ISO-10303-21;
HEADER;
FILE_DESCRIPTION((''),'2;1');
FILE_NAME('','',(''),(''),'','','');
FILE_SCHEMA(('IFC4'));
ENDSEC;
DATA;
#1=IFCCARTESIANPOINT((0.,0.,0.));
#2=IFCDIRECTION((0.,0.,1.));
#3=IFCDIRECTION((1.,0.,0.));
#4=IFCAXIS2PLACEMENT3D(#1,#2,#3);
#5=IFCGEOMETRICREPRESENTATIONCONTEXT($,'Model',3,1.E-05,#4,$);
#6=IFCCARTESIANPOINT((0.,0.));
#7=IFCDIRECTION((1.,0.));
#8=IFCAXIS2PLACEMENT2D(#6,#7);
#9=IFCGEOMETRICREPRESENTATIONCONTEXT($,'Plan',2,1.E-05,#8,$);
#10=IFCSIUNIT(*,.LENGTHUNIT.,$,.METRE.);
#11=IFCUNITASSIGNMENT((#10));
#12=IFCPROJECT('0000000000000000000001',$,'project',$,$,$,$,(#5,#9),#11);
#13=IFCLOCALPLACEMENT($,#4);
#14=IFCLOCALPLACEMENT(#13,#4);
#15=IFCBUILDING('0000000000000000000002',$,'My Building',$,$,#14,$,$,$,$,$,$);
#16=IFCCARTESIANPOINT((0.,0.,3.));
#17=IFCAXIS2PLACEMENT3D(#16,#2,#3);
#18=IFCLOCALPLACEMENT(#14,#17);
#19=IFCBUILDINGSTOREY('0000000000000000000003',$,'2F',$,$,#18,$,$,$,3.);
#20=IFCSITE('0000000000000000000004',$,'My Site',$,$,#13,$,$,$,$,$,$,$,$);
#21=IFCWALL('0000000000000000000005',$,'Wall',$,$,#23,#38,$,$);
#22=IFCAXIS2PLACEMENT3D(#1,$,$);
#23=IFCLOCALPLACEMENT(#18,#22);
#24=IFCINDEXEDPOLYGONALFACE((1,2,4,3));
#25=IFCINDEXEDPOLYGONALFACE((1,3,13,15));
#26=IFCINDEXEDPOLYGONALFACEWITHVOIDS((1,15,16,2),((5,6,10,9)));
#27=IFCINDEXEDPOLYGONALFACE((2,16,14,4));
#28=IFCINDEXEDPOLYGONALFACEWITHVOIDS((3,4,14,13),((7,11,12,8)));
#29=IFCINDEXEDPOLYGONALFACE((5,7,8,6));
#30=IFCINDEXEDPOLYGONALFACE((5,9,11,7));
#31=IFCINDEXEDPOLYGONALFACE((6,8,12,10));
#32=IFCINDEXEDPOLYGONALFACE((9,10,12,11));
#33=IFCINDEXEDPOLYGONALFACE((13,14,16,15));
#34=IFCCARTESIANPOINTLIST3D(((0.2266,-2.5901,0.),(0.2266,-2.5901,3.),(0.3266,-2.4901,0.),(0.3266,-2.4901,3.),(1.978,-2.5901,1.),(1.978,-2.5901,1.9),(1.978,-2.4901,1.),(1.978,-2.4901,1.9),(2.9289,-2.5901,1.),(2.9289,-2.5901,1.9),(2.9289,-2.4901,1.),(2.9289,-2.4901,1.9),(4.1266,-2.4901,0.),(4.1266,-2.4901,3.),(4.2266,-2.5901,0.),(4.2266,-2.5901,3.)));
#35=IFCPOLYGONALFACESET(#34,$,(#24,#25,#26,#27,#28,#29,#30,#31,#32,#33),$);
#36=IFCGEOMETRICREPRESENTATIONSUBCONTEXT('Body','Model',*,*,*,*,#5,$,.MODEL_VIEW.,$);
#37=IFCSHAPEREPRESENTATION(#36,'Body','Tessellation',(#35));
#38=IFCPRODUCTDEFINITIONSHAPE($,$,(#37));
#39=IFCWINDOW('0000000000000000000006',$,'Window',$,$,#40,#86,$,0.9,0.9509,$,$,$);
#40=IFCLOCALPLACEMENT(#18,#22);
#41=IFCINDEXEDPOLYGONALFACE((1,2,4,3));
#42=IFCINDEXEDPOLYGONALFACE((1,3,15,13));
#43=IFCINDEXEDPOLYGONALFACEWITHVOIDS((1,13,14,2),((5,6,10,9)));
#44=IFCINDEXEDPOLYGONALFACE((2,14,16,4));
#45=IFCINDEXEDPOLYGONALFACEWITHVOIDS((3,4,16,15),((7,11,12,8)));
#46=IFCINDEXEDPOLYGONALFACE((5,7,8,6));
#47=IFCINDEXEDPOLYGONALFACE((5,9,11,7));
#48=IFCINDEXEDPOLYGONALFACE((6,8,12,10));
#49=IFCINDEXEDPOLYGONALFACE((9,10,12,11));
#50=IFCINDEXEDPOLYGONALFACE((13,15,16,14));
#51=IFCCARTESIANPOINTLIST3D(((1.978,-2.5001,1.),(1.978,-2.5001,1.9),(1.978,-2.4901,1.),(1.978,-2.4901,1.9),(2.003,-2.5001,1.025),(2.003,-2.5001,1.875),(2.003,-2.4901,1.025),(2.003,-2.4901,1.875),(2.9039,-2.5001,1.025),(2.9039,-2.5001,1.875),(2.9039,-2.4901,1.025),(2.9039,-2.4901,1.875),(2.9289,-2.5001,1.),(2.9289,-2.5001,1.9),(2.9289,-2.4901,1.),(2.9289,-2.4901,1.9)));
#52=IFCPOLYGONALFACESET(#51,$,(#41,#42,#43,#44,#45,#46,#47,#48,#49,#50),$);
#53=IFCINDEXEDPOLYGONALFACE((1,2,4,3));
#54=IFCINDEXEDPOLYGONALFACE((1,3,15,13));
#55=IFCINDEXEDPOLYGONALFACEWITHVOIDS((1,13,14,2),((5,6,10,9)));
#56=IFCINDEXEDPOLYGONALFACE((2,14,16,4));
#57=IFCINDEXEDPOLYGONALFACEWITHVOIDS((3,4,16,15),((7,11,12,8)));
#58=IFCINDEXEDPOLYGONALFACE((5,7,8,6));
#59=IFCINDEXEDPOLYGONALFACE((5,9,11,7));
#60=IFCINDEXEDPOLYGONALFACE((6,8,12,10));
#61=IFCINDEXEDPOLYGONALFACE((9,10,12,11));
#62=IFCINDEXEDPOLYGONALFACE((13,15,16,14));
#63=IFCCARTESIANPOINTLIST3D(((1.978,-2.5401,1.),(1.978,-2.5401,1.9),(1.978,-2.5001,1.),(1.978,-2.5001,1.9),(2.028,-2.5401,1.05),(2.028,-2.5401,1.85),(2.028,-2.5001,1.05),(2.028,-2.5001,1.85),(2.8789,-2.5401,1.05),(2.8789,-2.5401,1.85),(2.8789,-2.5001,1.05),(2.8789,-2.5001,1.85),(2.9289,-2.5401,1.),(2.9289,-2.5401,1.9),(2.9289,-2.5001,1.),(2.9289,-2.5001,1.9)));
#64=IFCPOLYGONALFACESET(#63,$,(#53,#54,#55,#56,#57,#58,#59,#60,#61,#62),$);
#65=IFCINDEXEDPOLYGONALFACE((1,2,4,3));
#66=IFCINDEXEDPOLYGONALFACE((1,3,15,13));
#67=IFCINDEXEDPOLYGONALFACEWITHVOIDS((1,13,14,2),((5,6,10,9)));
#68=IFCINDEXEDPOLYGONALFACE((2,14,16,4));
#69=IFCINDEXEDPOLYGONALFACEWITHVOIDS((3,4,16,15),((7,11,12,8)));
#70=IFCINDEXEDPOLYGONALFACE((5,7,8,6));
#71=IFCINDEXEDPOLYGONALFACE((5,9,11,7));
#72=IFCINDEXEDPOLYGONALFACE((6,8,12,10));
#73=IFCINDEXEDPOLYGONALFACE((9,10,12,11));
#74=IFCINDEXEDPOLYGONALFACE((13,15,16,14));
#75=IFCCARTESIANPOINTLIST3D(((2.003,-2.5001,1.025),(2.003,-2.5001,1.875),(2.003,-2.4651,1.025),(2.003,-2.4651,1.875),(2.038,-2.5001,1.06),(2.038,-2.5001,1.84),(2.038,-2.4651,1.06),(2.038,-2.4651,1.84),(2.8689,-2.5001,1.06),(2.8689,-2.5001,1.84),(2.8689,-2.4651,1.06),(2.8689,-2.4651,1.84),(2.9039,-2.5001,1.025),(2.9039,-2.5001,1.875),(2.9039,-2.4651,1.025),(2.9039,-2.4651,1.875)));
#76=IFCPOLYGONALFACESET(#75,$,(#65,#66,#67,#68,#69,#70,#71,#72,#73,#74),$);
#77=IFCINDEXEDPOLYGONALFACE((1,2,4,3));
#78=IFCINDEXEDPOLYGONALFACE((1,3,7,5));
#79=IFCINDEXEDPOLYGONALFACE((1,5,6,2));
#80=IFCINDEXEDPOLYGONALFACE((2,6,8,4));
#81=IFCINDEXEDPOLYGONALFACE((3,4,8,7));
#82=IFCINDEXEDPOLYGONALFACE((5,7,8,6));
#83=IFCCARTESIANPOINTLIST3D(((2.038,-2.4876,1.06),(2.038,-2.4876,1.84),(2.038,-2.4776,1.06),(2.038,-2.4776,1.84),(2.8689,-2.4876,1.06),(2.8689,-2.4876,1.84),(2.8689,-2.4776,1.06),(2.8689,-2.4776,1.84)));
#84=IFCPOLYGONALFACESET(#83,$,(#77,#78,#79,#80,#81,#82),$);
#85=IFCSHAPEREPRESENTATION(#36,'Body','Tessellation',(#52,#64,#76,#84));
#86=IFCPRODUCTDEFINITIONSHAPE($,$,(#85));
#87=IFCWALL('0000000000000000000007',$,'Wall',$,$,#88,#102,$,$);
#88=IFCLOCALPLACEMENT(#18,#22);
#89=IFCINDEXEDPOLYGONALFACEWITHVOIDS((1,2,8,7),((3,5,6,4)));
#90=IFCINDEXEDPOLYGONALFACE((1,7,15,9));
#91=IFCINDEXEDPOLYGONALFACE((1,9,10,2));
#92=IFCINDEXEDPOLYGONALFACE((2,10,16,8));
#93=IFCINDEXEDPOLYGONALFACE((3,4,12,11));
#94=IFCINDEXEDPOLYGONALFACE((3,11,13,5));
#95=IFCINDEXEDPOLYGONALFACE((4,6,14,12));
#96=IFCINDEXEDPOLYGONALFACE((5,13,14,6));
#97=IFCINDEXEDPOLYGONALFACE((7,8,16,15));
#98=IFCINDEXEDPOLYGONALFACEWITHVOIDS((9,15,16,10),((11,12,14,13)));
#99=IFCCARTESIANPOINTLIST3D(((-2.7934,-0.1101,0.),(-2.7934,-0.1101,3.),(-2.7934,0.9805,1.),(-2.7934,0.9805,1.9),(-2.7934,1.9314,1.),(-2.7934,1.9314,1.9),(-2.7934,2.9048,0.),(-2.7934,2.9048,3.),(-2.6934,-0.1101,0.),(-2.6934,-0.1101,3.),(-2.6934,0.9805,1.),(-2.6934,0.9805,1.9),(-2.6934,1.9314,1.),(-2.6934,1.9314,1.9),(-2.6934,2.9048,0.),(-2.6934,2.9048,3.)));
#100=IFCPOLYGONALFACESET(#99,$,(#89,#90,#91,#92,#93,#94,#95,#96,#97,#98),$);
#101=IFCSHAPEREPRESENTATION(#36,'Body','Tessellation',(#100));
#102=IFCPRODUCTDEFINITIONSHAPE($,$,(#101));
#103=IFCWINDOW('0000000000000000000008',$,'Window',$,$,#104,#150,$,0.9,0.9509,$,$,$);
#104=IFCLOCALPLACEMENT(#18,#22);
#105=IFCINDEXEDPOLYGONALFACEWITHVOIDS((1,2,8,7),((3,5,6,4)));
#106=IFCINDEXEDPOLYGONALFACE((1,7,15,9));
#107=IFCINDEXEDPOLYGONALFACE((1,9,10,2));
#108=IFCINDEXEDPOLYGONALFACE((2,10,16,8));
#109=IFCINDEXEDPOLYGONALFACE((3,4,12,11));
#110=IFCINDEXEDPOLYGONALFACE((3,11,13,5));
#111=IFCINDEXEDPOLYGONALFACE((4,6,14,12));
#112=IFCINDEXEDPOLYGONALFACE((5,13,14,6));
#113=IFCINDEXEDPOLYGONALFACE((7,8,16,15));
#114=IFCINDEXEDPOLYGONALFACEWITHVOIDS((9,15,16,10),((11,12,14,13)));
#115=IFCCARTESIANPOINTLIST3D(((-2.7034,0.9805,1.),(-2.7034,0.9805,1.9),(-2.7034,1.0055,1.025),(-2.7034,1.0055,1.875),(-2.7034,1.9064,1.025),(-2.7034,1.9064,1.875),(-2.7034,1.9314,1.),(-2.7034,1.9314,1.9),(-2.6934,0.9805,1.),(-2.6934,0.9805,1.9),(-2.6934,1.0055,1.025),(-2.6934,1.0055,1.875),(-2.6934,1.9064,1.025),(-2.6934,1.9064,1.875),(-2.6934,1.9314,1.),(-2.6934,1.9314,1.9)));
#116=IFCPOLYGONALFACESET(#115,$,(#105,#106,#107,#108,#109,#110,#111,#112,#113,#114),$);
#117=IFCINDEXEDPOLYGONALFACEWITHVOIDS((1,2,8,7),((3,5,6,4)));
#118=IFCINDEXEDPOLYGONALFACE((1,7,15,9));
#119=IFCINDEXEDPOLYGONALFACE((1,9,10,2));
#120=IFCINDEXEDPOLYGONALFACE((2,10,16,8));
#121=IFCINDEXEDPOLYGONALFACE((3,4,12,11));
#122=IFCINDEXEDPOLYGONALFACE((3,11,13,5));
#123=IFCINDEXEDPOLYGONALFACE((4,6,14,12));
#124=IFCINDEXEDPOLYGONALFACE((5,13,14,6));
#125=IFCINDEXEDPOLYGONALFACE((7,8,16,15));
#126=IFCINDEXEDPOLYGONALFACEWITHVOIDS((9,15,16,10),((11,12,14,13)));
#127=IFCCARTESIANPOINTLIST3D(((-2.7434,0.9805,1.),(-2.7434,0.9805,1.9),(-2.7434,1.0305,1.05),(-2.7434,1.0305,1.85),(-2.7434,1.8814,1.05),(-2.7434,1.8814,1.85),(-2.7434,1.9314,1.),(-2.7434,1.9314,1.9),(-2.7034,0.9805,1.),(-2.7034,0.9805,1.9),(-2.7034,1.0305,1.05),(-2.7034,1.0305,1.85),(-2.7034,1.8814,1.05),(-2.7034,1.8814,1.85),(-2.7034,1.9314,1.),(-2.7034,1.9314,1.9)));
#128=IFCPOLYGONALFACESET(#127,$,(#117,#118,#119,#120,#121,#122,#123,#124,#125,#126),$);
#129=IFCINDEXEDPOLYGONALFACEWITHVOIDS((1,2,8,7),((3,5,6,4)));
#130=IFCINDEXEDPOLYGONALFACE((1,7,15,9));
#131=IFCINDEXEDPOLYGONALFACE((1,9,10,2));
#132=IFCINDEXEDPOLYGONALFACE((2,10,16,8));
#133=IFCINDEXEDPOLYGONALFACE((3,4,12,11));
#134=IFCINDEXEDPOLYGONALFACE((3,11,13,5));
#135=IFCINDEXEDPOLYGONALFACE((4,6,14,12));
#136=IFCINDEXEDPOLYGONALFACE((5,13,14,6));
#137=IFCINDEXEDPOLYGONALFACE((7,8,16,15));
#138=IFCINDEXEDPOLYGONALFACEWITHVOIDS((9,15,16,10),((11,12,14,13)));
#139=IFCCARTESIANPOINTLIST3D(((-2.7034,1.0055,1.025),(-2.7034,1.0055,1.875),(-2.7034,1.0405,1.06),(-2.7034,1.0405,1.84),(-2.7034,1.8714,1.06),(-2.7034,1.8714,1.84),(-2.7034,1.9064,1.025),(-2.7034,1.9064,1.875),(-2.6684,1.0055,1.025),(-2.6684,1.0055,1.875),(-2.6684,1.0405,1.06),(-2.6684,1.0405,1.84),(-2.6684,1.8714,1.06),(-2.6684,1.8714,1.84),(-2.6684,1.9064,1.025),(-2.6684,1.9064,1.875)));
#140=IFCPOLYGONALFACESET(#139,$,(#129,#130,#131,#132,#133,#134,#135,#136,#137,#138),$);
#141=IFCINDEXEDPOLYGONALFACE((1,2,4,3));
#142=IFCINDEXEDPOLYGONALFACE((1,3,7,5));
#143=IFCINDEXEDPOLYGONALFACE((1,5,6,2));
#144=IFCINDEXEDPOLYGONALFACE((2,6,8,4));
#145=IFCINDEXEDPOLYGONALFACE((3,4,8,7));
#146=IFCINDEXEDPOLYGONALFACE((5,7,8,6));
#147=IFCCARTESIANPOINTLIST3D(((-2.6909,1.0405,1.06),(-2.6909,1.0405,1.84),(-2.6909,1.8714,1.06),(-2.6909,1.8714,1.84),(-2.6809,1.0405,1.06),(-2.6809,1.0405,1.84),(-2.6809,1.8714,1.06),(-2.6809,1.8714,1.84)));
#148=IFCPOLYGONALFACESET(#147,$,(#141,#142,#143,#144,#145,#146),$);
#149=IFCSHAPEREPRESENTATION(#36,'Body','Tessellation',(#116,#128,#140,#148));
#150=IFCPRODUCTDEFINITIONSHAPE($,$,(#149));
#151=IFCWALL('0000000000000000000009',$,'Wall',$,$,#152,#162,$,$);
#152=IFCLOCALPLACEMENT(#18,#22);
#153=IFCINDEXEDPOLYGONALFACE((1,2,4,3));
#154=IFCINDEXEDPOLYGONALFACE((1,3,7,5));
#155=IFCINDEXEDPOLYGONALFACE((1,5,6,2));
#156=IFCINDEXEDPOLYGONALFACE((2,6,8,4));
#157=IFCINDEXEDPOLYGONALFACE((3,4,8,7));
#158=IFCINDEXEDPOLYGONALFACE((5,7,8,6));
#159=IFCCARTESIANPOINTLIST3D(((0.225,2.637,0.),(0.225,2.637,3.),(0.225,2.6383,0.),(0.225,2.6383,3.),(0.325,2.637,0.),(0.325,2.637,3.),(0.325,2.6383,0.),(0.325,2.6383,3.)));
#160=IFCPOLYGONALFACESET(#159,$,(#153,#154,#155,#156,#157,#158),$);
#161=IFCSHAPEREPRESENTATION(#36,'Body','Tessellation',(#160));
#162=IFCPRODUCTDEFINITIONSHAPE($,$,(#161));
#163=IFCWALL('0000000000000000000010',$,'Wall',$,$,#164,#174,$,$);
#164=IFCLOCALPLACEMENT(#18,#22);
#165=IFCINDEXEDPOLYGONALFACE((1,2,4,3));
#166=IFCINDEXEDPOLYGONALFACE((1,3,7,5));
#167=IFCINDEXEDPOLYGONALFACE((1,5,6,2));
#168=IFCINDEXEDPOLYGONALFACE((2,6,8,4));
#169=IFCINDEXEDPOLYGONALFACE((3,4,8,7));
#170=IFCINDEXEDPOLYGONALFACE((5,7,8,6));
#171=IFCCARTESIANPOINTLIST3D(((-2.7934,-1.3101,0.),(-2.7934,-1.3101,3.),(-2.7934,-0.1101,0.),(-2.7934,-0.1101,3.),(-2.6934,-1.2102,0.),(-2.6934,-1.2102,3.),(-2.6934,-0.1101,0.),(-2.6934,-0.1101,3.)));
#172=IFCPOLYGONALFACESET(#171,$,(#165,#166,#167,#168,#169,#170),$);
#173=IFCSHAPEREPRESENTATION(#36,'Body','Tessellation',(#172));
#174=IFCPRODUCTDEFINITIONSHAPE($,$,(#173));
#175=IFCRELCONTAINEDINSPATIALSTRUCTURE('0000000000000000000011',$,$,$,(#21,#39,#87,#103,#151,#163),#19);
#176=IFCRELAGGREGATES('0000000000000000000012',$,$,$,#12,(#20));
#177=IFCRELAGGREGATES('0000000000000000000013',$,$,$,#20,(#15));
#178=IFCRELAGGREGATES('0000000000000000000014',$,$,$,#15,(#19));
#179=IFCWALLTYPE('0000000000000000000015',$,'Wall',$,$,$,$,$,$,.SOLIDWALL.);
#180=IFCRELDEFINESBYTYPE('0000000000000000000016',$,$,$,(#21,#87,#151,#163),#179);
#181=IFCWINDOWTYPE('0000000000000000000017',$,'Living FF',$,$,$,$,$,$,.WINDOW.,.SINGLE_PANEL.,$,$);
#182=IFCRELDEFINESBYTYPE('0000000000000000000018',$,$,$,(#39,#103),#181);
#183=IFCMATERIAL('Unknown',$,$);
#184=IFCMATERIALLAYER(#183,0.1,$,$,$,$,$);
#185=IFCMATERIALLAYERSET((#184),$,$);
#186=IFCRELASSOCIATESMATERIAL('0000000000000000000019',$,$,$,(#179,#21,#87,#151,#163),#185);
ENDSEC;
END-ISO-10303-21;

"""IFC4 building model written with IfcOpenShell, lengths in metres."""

from ifc_helpers import new_model, entity, si_unit, frame, origin_with_axes, origin_2d_with_axis, place, context, subcontext, project, spatial, line, indexed_curve, outline, extrude, shape, source, transform, mapped, material, layer, layer_set, layer_usage, type_object, type_shapes, element, fill, save


model = new_model("IFC4")

# Units and contexts
model_context = context("Model", 3, precision=1e-05, world=origin_with_axes())
plan_context = context("Plan", 2, precision=1e-05, world=origin_2d_with_axis())
body_context_1 = subcontext(model_context, "Body", "Model", "MODEL_VIEW")
body_context_2 = subcontext(plan_context, "Body", "Plan", "PLAN_VIEW")
ifc_project = project(units=[si_unit("LENGTHUNIT", "METRE")], contexts=[model_context, plan_context])

# Site, building, storey
site_placement = place(None, origin_with_axes())
site = spatial("IfcSite", under=ifc_project, at=site_placement, Name="My Site")
building_placement = place(site_placement, origin_with_axes())
building = spatial("IfcBuilding", under=site, at=building_placement, Name="My Building")
storey_placement = place(building_placement, frame((0.0, 0.0, 3.0), z_axis=(0.0, 0.0, 1.0), x_axis=(1.0, 0.0, 0.0)))
storey = spatial("IfcBuildingStorey", under=building, at=storey_placement, Name="2F", Elevation=3.0)

# Shared definitions
ifc_material = material(Name="Unknown")

# Shared definitions
ifc_layer_1 = layer(ifc_material, 0.1)
ifc_layer_set_1 = layer_set([ifc_layer_1])
wall_type = type_object("IfcWallType", Name="Wall", PredefinedType="SOLIDWALL", material=ifc_layer_set_1)
shared_shape_1 = source(origin_with_axes(), body_context_1, "Body", "SweptSolid", [
    extrude(outline(indexed_curve([(0.0, 0.0), (0.9509, 0.0), (0.9509, 0.9), (0.0, 0.9)], segments=[line(1, 2, 3, 4, 1)])), frame((0.0, -0.6, 0.0), z_axis=(0.0, -1.0, 0.0), x_axis=(1.0, 0.0, 0.0)), (0.0, 0.0, -1.0), 1.2),
])
window_type_1 = type_object("IfcWindowType", Name="Living FF", PartitioningType="SINGLE_PANEL", PredefinedType="WINDOW")
shared_shape_2 = source(origin_with_axes(), body_context_1, "Body", "SweptSolid", [
    extrude(outline(indexed_curve([(0.0, 0.0), (0.9509, 0.0), (0.9509, 0.9), (0.0, 0.9)], segments=[line(1, 2, 3, 4, 1)]), holes=[indexed_curve([(0.025, 0.025), (0.9259, 0.025), (0.9259, 0.875), (0.025, 0.875)], segments=[line(1, 2, 3, 4, 1)])]), frame((0.0, 0.09, 0.0), z_axis=(0.0, -1.0, 0.0), x_axis=(1.0, 0.0, 0.0)), (0.0, 0.0, -1.0), 0.01),
    extrude(outline(indexed_curve([(0.0, 0.0), (0.9509, 0.0), (0.9509, 0.9), (0.0, 0.9)], segments=[line(1, 2, 3, 4, 1)]), holes=[indexed_curve([(0.05, 0.05), (0.9009, 0.05), (0.9009, 0.85), (0.05, 0.85)], segments=[line(1, 2, 3, 4, 1)])]), frame((0.0, 0.05, 0.0), z_axis=(0.0, -1.0, 0.0), x_axis=(1.0, 0.0, 0.0)), (0.0, 0.0, -1.0), 0.04),
    extrude(outline(indexed_curve([(0.0, 0.0), (0.9009, 0.0), (0.9009, 0.85), (0.0, 0.85)], segments=[line(1, 2, 3, 4, 1)]), holes=[indexed_curve([(0.035, 0.035), (0.8659, 0.035), (0.8659, 0.815), (0.035, 0.815)], segments=[line(1, 2, 3, 4, 1)])]), frame((0.025, 0.09, 0.025), z_axis=(0.0, -1.0, 0.0), x_axis=(1.0, 0.0, 0.0)), (0.0, 0.0, -1.0), 0.035),
    extrude(outline(indexed_curve([(0.035, 0.035), (0.8659, 0.035), (0.8659, 0.815), (0.035, 0.815)], segments=[line(1, 2, 3, 4, 1)])), frame((0.025, 0.1025, 0.025), z_axis=(0.0, -1.0, 0.0), x_axis=(1.0, 0.0, 0.0)), (0.0, 0.0, -1.0), 0.01),
])
shared_shape_3 = source(origin_with_axes(), body_context_2, "Body", "Curve2D", [
    entity("IfcIndexedPolyCurve", entity("IfcCartesianPointList2D", [[0.05, 0.05], [0.9009, 0.05]])),
    entity("IfcIndexedPolyCurve", entity("IfcCartesianPointList2D", [[0.0, 0.1], [0.025, 0.1], [0.025, 0.09], [0.05, 0.09], [0.05, 0.05], [0.0, 0.05]]), [entity("IfcLineIndex", [1, 2, 3, 4, 5, 6, 1])]),
    entity("IfcIndexedPolyCurve", entity("IfcCartesianPointList2D", [[0.9509, 0.1], [0.9259, 0.1], [0.9259, 0.09], [0.9009, 0.09], [0.9009, 0.05], [0.9509, 0.05]]), [entity("IfcLineIndex", [1, 2, 3, 4, 5, 6, 1])]),
    entity("IfcIndexedPolyCurve", entity("IfcCartesianPointList2D", [[0.025, 0.09], [0.06, 0.09], [0.06, 0.125], [0.025, 0.125]]), [entity("IfcLineIndex", [1, 2, 3, 4, 1])]),
    entity("IfcIndexedPolyCurve", entity("IfcCartesianPointList2D", [[0.9259, 0.09], [0.8909, 0.09], [0.8909, 0.125], [0.9259, 0.125]]), [entity("IfcLineIndex", [1, 2, 3, 4, 1])]),
    entity("IfcIndexedPolyCurve", entity("IfcCartesianPointList2D", [[0.06, 0.09], [0.8909, 0.09]])),
    entity("IfcIndexedPolyCurve", entity("IfcCartesianPointList2D", [[0.06, 0.125], [0.8909, 0.125]])),
    entity("IfcIndexedPolyCurve", entity("IfcCartesianPointList2D", [[0.06, 0.1075], [0.8909, 0.1075]])),
])
type_shapes(window_type_1, [shared_shape_2, shared_shape_3])

# Walls, openings, windows
ifc_layer_usage_1 = layer_usage(ifc_layer_set_1, "AXIS2", "POSITIVE", 0.0)
wall_1_placement = place(storey_placement, frame((0.2266, -2.5901, 0.0), z_axis=(0.0, 0.0, 1.0), x_axis=(1.0, 0.0, 0.0)))
wall_1 = element("IfcWall", 1, at=wall_1_placement, inside=storey, type_object=wall_type, material=ifc_layer_usage_1, Name="Wall", context=body_context_1, shape_type="SweptSolid", body=[
    extrude(outline(indexed_curve([(0.0, 0.0), (0.1, 0.1), (3.9, 0.1), (4.0, 0.0)], segments=[line(1, 2, 3, 4, 1)])), origin_with_axes(), (0.0, 0.0, 1.0), 3.0),
])
opening_1_placement = place(wall_1_placement, frame((1.7514, 0.0, 1.0), z_axis=(0.0, 0.0, 1.0), x_axis=(1.0, 0.0, 0.0)))
opening_1 = element("IfcOpeningElement", 2, at=opening_1_placement, cuts=wall_1, PredefinedType="OPENING", context=body_context_1, shape_type="MappedRepresentation", body=[
    mapped(shared_shape_1, transform((0.0, 0.0, 0.0), x_axis=(1.0, 0.0, 0.0), y_axis=(0.0, 1.0, 0.0), z_axis=(0.0, 0.0, 1.0), scale=1.0)),
])
window_1_placement = place(opening_1_placement, origin_with_axes())
window_1 = element("IfcWindow", 3, at=window_1_placement, inside=storey, type_object=window_type_1, Name="Window", OverallHeight=0.9, OverallWidth=0.9509, shapes=[
    shape(body_context_1, "Body", "MappedRepresentation", [mapped(shared_shape_2, transform((0.0, 0.0, 0.0), x_axis=(1.0, 0.0, 0.0), y_axis=(0.0, 1.0, 0.0), z_axis=(0.0, 0.0, 1.0), scale=1.0))]),
    shape(body_context_2, "Body", "MappedRepresentation", [mapped(shared_shape_3, transform((0.0, 0.0, 0.0), x_axis=(1.0, 0.0, 0.0), y_axis=(0.0, 1.0, 0.0), z_axis=(0.0, 0.0, 1.0), scale=1.0))]),
])
fill(opening_1, window_1)
ifc_layer_usage_2 = layer_usage(ifc_layer_set_1, "AXIS2", "POSITIVE", 0.0)
wall_2_placement = place(storey_placement, frame((-2.7934, 2.9048, 0.0), z_axis=(0.0, 0.0, 1.0), x_axis=(0.0, -1.0, 0.0)))
wall_2 = element("IfcWall", 4, at=wall_2_placement, inside=storey, type_object=wall_type, material=ifc_layer_usage_2, Name="Wall", context=body_context_1, shape_type="SweptSolid", body=[
    extrude(outline(indexed_curve([(0.0, 0.0), (0.0, 0.1), (3.0149, 0.1), (3.0149, 0.0)], segments=[line(1, 2, 3, 4, 1)])), origin_with_axes(), (0.0, 0.0, 1.0), 3.0),
])
opening_2_placement = place(wall_2_placement, frame((0.9734, 0.0, 1.0), z_axis=(0.0, 0.0, 1.0), x_axis=(1.0, 0.0, 0.0)))
opening_2 = element("IfcOpeningElement", 5, at=opening_2_placement, cuts=wall_2, PredefinedType="OPENING", context=body_context_1, shape_type="MappedRepresentation", body=[
    mapped(shared_shape_1, transform((0.0, 0.0, 0.0), x_axis=(1.0, 0.0, 0.0), y_axis=(0.0, 1.0, 0.0), z_axis=(0.0, 0.0, 1.0), scale=1.0)),
])
window_2_placement = place(opening_2_placement, frame((0.0, 0.0, 0.0), z_axis=(0.0, 0.0, 1.0), x_axis=(1.0, 0.0, 0.0)))
window_2 = element("IfcWindow", 6, at=window_2_placement, inside=storey, type_object=window_type_1, Name="Window", OverallHeight=0.9, OverallWidth=0.9509, shapes=[
    shape(body_context_1, "Body", "MappedRepresentation", [mapped(shared_shape_2, transform((0.0, 0.0, 0.0), x_axis=(1.0, 0.0, 0.0), y_axis=(0.0, 1.0, 0.0), z_axis=(0.0, 0.0, 1.0), scale=1.0))]),
    shape(body_context_2, "Body", "MappedRepresentation", [mapped(shared_shape_3, transform((0.0, 0.0, 0.0), x_axis=(1.0, 0.0, 0.0), y_axis=(0.0, 1.0, 0.0), z_axis=(0.0, 0.0, 1.0), scale=1.0))]),
])
fill(opening_2, window_2)

# Walls
ifc_layer_usage_3 = layer_usage(ifc_layer_set_1, "AXIS2", "POSITIVE", 0.0)
wall_3_placement = place(storey_placement, frame((0.325, 2.637, 0.0), z_axis=(0.0, 0.0, 1.0), x_axis=(-0.000187, 1.0, 0.0)))
element("IfcWall", 7, at=wall_3_placement, inside=storey, type_object=wall_type, material=ifc_layer_usage_3, Name="Wall", context=body_context_1, shape_type="SweptSolid", body=[
    extrude(outline(indexed_curve([(0.0, 0.0), (0.0, 0.1), (0.0013, 0.1), (0.0013, 0.0)], segments=[line(1, 2, 3, 4, 1)])), origin_with_axes(), (0.0, 0.0, 1.0), 3.0),
])
ifc_layer_usage_4 = layer_usage(ifc_layer_set_1, "AXIS2", "POSITIVE", 0.0)
wall_4_placement = place(storey_placement, frame((-2.7934, -0.1101, 0.0), z_axis=(0.0, 0.0, 1.0), x_axis=(0.0, -1.0, 0.0)))
element("IfcWall", 8, at=wall_4_placement, inside=storey, type_object=wall_type, material=ifc_layer_usage_4, Name="Wall", context=body_context_1, shape_type="SweptSolid", body=[
    extrude(outline(indexed_curve([(0.0, 0.0), (0.0, 0.1), (1.1, 0.1), (1.2, 0.0)], segments=[line(1, 2, 3, 4, 1)])), origin_with_axes(), (0.0, 0.0, 1.0), 3.0),
])

save(model, "model.ifc")
